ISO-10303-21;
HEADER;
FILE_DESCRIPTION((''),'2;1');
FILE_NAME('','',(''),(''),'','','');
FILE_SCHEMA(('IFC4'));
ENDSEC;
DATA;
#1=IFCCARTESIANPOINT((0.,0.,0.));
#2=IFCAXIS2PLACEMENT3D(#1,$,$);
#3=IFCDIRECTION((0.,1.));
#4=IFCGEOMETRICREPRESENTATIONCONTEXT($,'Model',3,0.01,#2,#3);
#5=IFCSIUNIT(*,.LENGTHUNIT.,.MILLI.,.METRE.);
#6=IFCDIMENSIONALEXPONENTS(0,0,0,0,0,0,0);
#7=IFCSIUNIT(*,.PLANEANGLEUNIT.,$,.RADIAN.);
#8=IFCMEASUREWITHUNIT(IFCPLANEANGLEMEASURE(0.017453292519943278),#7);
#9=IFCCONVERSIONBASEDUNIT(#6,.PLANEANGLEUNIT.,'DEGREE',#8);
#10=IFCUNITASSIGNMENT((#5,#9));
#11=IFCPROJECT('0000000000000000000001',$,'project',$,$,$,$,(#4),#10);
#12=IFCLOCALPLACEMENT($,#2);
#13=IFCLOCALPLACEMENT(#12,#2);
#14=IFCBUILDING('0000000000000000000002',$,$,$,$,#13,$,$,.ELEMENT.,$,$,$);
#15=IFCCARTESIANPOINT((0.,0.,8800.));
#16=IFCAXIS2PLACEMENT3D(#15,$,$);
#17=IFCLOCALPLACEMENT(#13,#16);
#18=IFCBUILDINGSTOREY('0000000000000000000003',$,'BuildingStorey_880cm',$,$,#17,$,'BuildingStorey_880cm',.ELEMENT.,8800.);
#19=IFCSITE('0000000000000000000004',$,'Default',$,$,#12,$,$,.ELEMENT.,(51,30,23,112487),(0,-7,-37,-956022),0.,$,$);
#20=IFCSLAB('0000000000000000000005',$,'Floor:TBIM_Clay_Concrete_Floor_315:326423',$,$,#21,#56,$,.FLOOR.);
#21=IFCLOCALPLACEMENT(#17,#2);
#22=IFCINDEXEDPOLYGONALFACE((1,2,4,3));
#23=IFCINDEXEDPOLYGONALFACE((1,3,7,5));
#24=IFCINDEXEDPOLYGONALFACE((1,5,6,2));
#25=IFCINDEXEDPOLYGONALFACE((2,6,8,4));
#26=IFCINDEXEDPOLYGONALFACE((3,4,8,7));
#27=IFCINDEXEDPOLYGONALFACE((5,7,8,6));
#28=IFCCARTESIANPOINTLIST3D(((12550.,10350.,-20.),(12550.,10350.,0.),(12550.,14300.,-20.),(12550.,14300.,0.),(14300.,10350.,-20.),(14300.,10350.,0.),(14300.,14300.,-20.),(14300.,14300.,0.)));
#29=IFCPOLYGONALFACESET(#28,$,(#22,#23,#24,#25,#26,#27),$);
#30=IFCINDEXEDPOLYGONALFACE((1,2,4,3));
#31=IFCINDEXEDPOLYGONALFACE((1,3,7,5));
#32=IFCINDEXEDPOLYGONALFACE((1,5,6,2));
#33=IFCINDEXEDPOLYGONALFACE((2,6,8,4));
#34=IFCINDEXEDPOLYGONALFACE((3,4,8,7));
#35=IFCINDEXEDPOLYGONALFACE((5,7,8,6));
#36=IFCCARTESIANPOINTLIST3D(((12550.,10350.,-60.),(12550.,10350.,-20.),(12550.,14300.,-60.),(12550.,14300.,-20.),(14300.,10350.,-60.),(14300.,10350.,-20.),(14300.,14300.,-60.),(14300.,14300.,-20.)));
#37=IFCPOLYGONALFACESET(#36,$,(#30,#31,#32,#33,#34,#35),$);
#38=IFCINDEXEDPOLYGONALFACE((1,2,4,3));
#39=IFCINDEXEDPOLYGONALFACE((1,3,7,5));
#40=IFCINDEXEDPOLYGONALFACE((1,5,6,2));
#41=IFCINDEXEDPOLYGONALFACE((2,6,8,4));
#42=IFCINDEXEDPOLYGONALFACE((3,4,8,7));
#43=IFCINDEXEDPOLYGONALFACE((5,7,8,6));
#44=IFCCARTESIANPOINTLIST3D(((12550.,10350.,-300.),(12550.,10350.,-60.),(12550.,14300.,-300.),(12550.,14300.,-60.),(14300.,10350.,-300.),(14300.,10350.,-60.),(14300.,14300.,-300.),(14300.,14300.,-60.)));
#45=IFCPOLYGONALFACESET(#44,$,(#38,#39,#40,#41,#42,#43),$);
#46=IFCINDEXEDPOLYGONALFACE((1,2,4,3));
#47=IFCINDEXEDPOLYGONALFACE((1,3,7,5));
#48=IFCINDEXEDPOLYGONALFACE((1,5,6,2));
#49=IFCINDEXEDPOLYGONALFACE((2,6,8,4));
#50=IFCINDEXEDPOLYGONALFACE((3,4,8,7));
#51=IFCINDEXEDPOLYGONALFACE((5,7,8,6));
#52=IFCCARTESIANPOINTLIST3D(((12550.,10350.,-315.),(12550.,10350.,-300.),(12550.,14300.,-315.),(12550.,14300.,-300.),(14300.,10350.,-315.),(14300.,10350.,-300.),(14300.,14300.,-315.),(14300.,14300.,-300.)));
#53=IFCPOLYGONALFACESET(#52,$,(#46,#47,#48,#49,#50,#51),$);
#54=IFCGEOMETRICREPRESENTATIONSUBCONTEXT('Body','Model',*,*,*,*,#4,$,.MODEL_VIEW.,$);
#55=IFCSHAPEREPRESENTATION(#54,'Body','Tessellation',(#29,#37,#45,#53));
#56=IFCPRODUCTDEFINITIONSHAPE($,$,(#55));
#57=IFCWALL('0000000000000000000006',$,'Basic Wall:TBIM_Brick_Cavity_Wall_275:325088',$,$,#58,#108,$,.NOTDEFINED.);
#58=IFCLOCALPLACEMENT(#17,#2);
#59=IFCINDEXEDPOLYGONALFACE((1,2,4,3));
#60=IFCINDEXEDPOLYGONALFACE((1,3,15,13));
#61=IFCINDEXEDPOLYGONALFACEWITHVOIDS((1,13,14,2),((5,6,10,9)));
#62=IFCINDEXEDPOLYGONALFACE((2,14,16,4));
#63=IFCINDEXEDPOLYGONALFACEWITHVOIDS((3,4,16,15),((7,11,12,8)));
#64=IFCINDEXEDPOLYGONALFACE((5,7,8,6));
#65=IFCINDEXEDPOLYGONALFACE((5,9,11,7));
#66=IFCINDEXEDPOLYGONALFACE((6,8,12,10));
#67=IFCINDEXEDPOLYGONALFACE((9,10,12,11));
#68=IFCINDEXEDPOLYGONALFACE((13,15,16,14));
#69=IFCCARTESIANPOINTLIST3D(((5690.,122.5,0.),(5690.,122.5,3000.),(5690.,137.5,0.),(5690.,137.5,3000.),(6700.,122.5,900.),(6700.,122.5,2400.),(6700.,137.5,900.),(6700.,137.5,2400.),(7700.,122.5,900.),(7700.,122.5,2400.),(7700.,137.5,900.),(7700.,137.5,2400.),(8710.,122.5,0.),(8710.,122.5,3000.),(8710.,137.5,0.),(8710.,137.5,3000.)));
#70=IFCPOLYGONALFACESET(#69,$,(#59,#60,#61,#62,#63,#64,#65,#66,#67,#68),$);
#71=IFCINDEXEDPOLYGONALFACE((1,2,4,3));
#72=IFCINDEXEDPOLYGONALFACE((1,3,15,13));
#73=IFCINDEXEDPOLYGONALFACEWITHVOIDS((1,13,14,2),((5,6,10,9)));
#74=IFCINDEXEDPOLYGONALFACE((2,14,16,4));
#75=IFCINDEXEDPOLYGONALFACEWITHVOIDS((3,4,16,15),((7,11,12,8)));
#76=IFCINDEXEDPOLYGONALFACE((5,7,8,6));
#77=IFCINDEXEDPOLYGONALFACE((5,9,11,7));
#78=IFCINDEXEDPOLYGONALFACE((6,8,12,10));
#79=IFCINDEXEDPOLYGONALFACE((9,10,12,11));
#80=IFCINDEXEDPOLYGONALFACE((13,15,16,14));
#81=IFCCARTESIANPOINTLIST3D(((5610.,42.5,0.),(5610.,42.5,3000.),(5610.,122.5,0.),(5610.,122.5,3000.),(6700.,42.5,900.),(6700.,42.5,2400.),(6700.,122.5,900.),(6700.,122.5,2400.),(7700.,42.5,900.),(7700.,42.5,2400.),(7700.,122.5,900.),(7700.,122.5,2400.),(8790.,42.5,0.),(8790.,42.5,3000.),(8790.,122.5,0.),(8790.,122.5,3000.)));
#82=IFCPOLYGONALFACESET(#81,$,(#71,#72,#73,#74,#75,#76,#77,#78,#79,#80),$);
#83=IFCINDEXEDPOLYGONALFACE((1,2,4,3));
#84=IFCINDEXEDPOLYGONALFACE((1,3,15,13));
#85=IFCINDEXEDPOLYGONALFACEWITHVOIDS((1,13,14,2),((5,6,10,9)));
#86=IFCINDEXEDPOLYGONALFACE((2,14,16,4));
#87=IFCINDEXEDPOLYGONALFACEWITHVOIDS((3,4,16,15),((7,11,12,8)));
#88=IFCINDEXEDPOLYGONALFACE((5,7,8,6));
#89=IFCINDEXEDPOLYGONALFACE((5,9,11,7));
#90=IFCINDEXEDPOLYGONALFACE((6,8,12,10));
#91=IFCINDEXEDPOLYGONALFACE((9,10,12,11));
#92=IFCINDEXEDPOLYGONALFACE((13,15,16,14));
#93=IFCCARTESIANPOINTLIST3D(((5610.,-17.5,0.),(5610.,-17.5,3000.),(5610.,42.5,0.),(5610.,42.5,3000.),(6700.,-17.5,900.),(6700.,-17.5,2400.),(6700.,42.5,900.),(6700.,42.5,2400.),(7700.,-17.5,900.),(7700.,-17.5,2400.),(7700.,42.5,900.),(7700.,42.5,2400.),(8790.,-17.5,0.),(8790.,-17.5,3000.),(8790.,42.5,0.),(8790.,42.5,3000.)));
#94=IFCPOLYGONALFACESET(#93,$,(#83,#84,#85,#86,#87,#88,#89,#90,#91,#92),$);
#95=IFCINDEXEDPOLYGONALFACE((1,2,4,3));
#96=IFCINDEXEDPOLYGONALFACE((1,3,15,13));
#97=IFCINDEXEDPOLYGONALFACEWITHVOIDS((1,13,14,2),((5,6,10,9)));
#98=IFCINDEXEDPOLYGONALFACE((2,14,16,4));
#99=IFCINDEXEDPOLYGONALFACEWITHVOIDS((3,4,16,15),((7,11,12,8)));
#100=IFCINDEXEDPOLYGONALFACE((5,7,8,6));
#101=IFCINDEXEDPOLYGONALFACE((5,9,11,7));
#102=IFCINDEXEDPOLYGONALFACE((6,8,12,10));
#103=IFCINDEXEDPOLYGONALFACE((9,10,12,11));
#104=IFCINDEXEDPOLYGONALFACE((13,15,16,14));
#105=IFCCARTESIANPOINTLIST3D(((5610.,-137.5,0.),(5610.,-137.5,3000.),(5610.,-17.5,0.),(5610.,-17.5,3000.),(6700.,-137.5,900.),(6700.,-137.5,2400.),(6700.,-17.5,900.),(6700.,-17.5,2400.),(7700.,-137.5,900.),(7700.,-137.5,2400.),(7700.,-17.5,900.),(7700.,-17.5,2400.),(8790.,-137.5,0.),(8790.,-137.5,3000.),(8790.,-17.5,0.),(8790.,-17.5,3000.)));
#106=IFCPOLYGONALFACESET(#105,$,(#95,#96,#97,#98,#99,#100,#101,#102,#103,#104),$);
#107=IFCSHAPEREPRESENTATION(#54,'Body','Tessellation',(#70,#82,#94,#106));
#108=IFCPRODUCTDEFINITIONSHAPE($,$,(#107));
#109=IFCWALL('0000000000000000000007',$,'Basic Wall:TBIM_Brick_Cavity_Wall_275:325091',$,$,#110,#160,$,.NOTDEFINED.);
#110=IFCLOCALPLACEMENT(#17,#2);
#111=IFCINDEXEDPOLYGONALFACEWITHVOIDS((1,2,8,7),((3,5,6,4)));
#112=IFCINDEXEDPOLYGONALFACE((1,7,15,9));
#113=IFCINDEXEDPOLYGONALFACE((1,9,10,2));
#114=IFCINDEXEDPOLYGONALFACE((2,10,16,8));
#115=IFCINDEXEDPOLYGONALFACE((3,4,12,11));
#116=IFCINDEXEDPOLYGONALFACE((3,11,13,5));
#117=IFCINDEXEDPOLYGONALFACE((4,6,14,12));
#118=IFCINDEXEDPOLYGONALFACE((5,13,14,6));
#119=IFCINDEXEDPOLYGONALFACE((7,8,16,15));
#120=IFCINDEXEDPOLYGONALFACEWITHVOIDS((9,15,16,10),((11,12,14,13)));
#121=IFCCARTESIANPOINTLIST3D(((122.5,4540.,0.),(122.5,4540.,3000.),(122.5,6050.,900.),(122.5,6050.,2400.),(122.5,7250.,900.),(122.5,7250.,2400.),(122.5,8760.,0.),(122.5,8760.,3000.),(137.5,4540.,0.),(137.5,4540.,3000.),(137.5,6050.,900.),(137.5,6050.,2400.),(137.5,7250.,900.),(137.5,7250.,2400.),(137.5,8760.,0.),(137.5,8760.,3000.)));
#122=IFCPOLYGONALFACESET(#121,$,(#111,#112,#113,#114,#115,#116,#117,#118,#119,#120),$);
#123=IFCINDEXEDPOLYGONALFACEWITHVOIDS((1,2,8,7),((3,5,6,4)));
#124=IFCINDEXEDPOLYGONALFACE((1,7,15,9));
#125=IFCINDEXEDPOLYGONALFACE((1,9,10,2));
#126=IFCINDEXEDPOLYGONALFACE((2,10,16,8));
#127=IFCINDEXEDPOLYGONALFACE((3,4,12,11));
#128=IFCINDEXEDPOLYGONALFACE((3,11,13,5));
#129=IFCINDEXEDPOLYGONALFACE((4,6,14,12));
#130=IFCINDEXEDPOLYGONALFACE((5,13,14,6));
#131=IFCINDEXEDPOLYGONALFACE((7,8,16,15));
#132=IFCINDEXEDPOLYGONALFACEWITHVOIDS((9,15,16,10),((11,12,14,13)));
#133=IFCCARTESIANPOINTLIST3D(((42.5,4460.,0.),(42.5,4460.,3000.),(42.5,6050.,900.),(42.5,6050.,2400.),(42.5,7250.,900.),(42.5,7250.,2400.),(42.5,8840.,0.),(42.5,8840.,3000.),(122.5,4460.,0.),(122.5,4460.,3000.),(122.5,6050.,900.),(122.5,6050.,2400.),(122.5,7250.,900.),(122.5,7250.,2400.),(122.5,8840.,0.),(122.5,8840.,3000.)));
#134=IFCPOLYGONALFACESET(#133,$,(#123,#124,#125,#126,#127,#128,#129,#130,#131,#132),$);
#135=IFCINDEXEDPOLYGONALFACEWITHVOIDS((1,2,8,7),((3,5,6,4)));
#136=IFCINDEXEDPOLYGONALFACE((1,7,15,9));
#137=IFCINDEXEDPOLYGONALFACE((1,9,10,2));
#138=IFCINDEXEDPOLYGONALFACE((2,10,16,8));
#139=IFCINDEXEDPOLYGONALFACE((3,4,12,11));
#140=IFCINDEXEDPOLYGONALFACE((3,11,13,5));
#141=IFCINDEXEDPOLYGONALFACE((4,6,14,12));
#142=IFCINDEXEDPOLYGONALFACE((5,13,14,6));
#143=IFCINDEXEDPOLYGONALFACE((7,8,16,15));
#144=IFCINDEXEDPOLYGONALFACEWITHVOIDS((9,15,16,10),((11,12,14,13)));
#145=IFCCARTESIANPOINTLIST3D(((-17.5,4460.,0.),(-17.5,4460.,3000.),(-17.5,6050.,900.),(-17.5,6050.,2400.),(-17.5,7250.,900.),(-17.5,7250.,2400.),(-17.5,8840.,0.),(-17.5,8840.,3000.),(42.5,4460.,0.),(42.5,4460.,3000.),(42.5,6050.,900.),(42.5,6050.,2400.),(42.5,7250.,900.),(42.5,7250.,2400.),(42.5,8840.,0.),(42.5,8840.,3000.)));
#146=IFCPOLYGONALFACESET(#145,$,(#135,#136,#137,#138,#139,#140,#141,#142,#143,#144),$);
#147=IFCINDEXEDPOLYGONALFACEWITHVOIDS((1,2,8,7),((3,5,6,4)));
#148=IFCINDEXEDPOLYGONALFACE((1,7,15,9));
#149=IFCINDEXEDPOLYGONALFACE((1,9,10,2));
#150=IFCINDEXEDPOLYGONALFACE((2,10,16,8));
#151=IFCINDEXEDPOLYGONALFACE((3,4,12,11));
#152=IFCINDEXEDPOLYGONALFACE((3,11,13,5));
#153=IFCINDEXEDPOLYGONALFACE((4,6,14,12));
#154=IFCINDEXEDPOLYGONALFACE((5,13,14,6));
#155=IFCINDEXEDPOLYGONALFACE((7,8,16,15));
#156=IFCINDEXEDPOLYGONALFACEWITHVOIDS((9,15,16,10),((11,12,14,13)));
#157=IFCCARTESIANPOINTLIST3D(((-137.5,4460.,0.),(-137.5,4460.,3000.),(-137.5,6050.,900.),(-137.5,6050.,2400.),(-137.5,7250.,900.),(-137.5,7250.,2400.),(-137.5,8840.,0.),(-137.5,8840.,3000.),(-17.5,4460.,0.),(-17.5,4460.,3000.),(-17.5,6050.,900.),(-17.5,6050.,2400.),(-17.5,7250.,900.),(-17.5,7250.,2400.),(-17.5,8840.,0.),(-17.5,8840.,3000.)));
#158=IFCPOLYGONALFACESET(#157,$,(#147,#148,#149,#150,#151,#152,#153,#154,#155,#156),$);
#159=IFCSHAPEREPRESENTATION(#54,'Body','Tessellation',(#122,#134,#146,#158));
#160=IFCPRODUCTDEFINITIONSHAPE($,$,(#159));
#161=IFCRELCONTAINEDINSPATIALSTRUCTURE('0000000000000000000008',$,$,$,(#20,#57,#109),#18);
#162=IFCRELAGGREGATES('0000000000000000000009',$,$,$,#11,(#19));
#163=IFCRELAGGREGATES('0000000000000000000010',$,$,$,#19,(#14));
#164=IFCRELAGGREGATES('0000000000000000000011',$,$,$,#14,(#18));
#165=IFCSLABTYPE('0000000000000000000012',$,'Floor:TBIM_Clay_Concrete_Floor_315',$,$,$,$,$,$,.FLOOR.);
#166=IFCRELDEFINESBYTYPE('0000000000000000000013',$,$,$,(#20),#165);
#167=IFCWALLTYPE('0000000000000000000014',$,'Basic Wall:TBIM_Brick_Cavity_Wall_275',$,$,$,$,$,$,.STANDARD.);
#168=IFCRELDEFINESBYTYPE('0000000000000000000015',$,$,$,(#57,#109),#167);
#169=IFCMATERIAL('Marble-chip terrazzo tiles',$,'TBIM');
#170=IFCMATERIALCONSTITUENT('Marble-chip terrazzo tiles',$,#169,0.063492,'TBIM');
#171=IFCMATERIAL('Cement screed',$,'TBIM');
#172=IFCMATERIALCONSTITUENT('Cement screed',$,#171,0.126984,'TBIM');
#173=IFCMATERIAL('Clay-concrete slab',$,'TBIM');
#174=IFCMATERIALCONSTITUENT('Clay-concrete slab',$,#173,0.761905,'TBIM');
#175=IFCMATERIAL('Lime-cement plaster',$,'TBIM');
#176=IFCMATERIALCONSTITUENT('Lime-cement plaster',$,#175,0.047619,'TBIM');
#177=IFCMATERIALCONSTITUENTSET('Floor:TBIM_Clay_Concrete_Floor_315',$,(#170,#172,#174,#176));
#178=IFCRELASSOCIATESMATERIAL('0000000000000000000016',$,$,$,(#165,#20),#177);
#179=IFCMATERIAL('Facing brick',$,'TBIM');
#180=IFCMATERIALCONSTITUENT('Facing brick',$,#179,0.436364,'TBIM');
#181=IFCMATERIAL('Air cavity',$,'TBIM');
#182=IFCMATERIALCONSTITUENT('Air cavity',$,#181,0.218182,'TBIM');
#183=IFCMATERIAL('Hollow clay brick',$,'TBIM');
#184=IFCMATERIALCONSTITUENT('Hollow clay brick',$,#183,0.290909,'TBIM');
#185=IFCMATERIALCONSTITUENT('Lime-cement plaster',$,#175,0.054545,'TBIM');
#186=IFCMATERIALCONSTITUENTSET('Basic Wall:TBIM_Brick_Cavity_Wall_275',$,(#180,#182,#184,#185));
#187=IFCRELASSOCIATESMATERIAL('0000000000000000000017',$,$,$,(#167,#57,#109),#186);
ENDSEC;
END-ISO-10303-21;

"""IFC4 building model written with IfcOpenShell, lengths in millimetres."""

from ifc_helpers import new_model, entity, si_unit, converted_unit, direction, frame, origin, place, context, subcontext, project, spatial, indexed_curve, outline, extrude, material, constituent, constituent_set, type_object, element, save


model = new_model("IFC4")

# Units and contexts
model_context = context("Model", 3, precision=0.01, world=origin(), true_north=direction((0.0, 1.0)))
body_context = subcontext(model_context, "Body", "Model", "MODEL_VIEW")
ifc_project = project(units=[si_unit("LENGTHUNIT", "METRE", prefix="MILLI"), converted_unit("PLANEANGLEUNIT", "DEGREE", entity("IfcPlaneAngleMeasure", 0.017453292519943278), si_unit("PLANEANGLEUNIT", "RADIAN"), dimensions=[0, 0, 0, 0, 0, 0, 0])], contexts=[model_context])

# Site, building, storey
site_placement = place(None, origin())
site = spatial("IfcSite", under=ifc_project, at=site_placement, Name="Default", CompositionType="ELEMENT", RefLatitude=(51, 30, 23, 112487), RefLongitude=(0, -7, -37, -956022), RefElevation=0.0)
building_placement = place(site_placement, origin())
building = spatial("IfcBuilding", under=site, at=building_placement, CompositionType="ELEMENT")
storey_placement = place(building_placement, frame((0.0, 0.0, 8800.0)))
storey = spatial("IfcBuildingStorey", under=building, at=storey_placement, Name="BuildingStorey_880cm", LongName="BuildingStorey_880cm", CompositionType="ELEMENT", Elevation=8800.0)

# Slab
ifc_material_1 = material(Name="Marble-chip terrazzo tiles", Category="TBIM")
ifc_constituent_1 = constituent(ifc_material_1, Name="Marble-chip terrazzo tiles", Category="TBIM", fraction=0.063492)
ifc_material_2 = material(Name="Cement screed", Category="TBIM")
ifc_constituent_2 = constituent(ifc_material_2, Name="Cement screed", Category="TBIM", fraction=0.126984)
ifc_material_3 = material(Name="Clay-concrete slab", Category="TBIM")
ifc_constituent_3 = constituent(ifc_material_3, Name="Clay-concrete slab", Category="TBIM", fraction=0.761905)
ifc_material_4 = material(Name="Lime-cement plaster", Category="TBIM")
ifc_constituent_4 = constituent(ifc_material_4, Name="Lime-cement plaster", Category="TBIM", fraction=0.047619)
ifc_constituent_set_1 = constituent_set(constituents=[ifc_constituent_1, ifc_constituent_2, ifc_constituent_3, ifc_constituent_4], Name="Floor:TBIM_Clay_Concrete_Floor_315")
slab_type = type_object("IfcSlabType", Name="Floor:TBIM_Clay_Concrete_Floor_315", PredefinedType="FLOOR", material=ifc_constituent_set_1)
slab_1_placement = place(storey_placement, origin())
element("IfcSlab", 1, at=slab_1_placement, inside=storey, type_object=slab_type, material=ifc_constituent_set_1, Name="Floor:TBIM_Clay_Concrete_Floor_315:326423", PredefinedType="FLOOR", context=body_context, shape_type="SweptSolid", body=[
    extrude(outline(indexed_curve([(-875.0, -1975.0), (875.0, -1975.0), (875.0, 1975.0), (-875.0, 1975.0), (-875.0, -1975.0)], self_intersect=False)), frame((13425.0, 12325.0, -20.0), z_axis=(0.0, 0.0, 1.0), x_axis=(-1.0, 0.0, 0.0)), (0.0, 0.0, 1.0), 20.0),
    extrude(outline(indexed_curve([(-875.0, -1975.0), (875.0, -1975.0), (875.0, 1975.0), (-875.0, 1975.0), (-875.0, -1975.0)], self_intersect=False)), frame((13425.0, 12325.0, -60.0), z_axis=(0.0, 0.0, 1.0), x_axis=(-1.0, 0.0, 0.0)), (0.0, 0.0, 1.0), 40.0),
    extrude(outline(indexed_curve([(-875.0, -1975.0), (875.0, -1975.0), (875.0, 1975.0), (-875.0, 1975.0), (-875.0, -1975.0)], self_intersect=False)), frame((13425.0, 12325.0, -300.0), z_axis=(0.0, 0.0, 1.0), x_axis=(-1.0, 0.0, 0.0)), (0.0, 0.0, 1.0), 240.0),
    extrude(outline(indexed_curve([(-875.0, -1975.0), (875.0, -1975.0), (875.0, 1975.0), (-875.0, 1975.0), (-875.0, -1975.0)], self_intersect=False)), frame((13425.0, 12325.0, -315.0), z_axis=(0.0, 0.0, 1.0), x_axis=(-1.0, 0.0, 0.0)), (0.0, 0.0, 1.0), 15.0),
])

# Walls, openings
ifc_material_5 = material(Name="Facing brick", Category="TBIM")
ifc_constituent_5 = constituent(ifc_material_5, Name="Facing brick", Category="TBIM", fraction=0.436364)
ifc_material_6 = material(Name="Air cavity", Category="TBIM")
ifc_constituent_6 = constituent(ifc_material_6, Name="Air cavity", Category="TBIM", fraction=0.218182)
ifc_material_7 = material(Name="Hollow clay brick", Category="TBIM")
ifc_constituent_7 = constituent(ifc_material_7, Name="Hollow clay brick", Category="TBIM", fraction=0.290909)
ifc_constituent_8 = constituent(ifc_material_4, Name="Lime-cement plaster", Category="TBIM", fraction=0.054545)
ifc_constituent_set_2 = constituent_set(constituents=[ifc_constituent_5, ifc_constituent_6, ifc_constituent_7, ifc_constituent_8], Name="Basic Wall:TBIM_Brick_Cavity_Wall_275")
wall_type_1 = type_object("IfcWallType", Name="Basic Wall:TBIM_Brick_Cavity_Wall_275", PredefinedType="STANDARD", material=ifc_constituent_set_2)
wall_1_placement = place(storey_placement, frame((5595.0, 0.0, 0.0)))
wall_1 = element("IfcWall", 2, at=wall_1_placement, inside=storey, type_object=wall_type_1, material=ifc_constituent_set_2, Name="Basic Wall:TBIM_Brick_Cavity_Wall_275:325088", PredefinedType="NOTDEFINED", context=body_context, shape_type="SweptSolid", body=[
    extrude(outline(indexed_curve([(-1500.0, -1510.0), (1500.0, -1510.0), (1500.0, 1510.0), (-1500.0, 1510.0), (-1500.0, -1510.0)], self_intersect=False), holes=[indexed_curve([(-600.0, -500.0), (-600.0, 500.0), (900.0, 500.0), (900.0, -500.0), (-600.0, -500.0)], self_intersect=False)]), frame((1605.0, 122.5, 1500.0), z_axis=(0.0, 1.0, 0.0), x_axis=(0.0, 0.0, 1.0)), (0.0, 0.0, 1.0), 15.0),
    extrude(outline(indexed_curve([(-1500.0, -1590.0), (1500.0, -1590.0), (1500.0, 1590.0), (-1500.0, 1590.0), (-1500.0, -1590.0)], self_intersect=False), holes=[indexed_curve([(-600.0, -500.0), (-600.0, 500.0), (900.0, 500.0), (900.0, -500.0), (-600.0, -500.0)], self_intersect=False)]), frame((1605.0, 42.5, 1500.0), z_axis=(0.0, 1.0, 0.0), x_axis=(0.0, 0.0, 1.0)), (0.0, 0.0, 1.0), 80.0),
    extrude(outline(indexed_curve([(-1500.0, -1590.0), (1500.0, -1590.0), (1500.0, 1590.0), (-1500.0, 1590.0), (-1500.0, -1590.0)], self_intersect=False), holes=[indexed_curve([(-600.0, -500.0), (-600.0, 500.0), (900.0, 500.0), (900.0, -500.0), (-600.0, -500.0)], self_intersect=False)]), frame((1605.0, -17.5, 1500.0), z_axis=(0.0, 1.0, 0.0), x_axis=(0.0, 0.0, 1.0)), (0.0, 0.0, 1.0), 60.0),
    extrude(outline(indexed_curve([(-1500.0, -1590.0), (1500.0, -1590.0), (1500.0, 1590.0), (-1500.0, 1590.0), (-1500.0, -1590.0)], self_intersect=False), holes=[indexed_curve([(900.0, -500.0), (-600.0, -500.0), (-600.0, 500.0), (900.0, 500.0), (900.0, -500.0)], self_intersect=False)]), frame((1605.0, -137.5, 1500.0), z_axis=(0.0, 1.0, 0.0), x_axis=(0.0, 0.0, 1.0)), (0.0, 0.0, 1.0), 120.0),
])
opening_1_placement = place(wall_1_placement, frame((1105.0, -137.5, 900.0)))
element("IfcOpeningElement", 3, at=opening_1_placement, cuts=wall_1, PredefinedType="OPENING", context=body_context, shape_type="SweptSolid", body=[
    extrude(outline(indexed_curve([(1500.0, 0.0), (1500.0, 1000.0), (0.0, 1000.0), (0.0, 0.0), (1500.0, 0.0)], self_intersect=False)), frame((0.0, 0.0, 0.0), z_axis=(0.0, 1.0, 0.0), x_axis=(0.0, 0.0, 1.0)), (0.0, 0.0, 1.0), 275.0),
])
wall_2_placement = place(storey_placement, frame((0.0, 4445.0, 0.0), z_axis=(0.0, 0.0, 1.0), x_axis=(0.0, 1.0, 0.0)))
wall_2 = element("IfcWall", 4, at=wall_2_placement, inside=storey, type_object=wall_type_1, material=ifc_constituent_set_2, Name="Basic Wall:TBIM_Brick_Cavity_Wall_275:325091", PredefinedType="NOTDEFINED", context=body_context, shape_type="SweptSolid", body=[
    extrude(outline(indexed_curve([(-1500.0, -2110.0), (1500.0, -2110.0), (1500.0, 2110.0), (-1500.0, 2110.0), (-1500.0, -2110.0)], self_intersect=False), holes=[indexed_curve([(900.0, 600.0), (900.0, -600.0), (-600.0, -600.0), (-600.0, 600.0), (900.0, 600.0)], self_intersect=False)]), frame((2205.0, -122.5, 1500.0), z_axis=(0.0, -1.0, 0.0), x_axis=(0.0, 0.0, 1.0)), (0.0, 0.0, 1.0), 15.0),
    extrude(outline(indexed_curve([(-1500.0, -2190.0), (1500.0, -2190.0), (1500.0, 2190.0), (-1500.0, 2190.0), (-1500.0, -2190.0)], self_intersect=False), holes=[indexed_curve([(900.0, 600.0), (900.0, -600.0), (-600.0, -600.0), (-600.0, 600.0), (900.0, 600.0)], self_intersect=False)]), frame((2205.0, -42.5, 1500.0), z_axis=(0.0, -1.0, 0.0), x_axis=(0.0, 0.0, 1.0)), (0.0, 0.0, 1.0), 80.0),
    extrude(outline(indexed_curve([(-1500.0, -2190.0), (1500.0, -2190.0), (1500.0, 2190.0), (-1500.0, 2190.0), (-1500.0, -2190.0)], self_intersect=False), holes=[indexed_curve([(900.0, 600.0), (900.0, -600.0), (-600.0, -600.0), (-600.0, 600.0), (900.0, 600.0)], self_intersect=False)]), frame((2205.0, 17.5, 1500.0), z_axis=(0.0, -1.0, 0.0), x_axis=(0.0, 0.0, 1.0)), (0.0, 0.0, 1.0), 60.0),
    extrude(outline(indexed_curve([(-2190.0, -1500.0), (2190.0, -1500.0), (2190.0, 1500.0), (-2190.0, 1500.0), (-2190.0, -1500.0)], self_intersect=False), holes=[indexed_curve([(-600.0, 900.0), (600.0, 900.0), (600.0, -600.0), (-600.0, -600.0), (-600.0, 900.0)], self_intersect=False)]), frame((2205.0, 137.5, 1500.0), z_axis=(0.0, -1.0, 0.0), x_axis=(1.0, 0.0, 0.0)), (0.0, 0.0, 1.0), 120.0),
])
opening_2_placement = place(wall_2_placement, frame((1605.0, -137.5, 900.0)))
element("IfcOpeningElement", 5, at=opening_2_placement, cuts=wall_2, PredefinedType="OPENING", context=body_context, shape_type="SweptSolid", body=[
    extrude(outline(indexed_curve([(1500.0, 0.0), (1500.0, 1200.0), (0.0, 1200.0), (0.0, 0.0), (1500.0, 0.0)], self_intersect=False)), frame((0.0, 0.0, 0.0), z_axis=(0.0, 1.0, 0.0), x_axis=(0.0, 0.0, 1.0)), (0.0, 0.0, 1.0), 275.0),
])

save(model, "model.ifc")
